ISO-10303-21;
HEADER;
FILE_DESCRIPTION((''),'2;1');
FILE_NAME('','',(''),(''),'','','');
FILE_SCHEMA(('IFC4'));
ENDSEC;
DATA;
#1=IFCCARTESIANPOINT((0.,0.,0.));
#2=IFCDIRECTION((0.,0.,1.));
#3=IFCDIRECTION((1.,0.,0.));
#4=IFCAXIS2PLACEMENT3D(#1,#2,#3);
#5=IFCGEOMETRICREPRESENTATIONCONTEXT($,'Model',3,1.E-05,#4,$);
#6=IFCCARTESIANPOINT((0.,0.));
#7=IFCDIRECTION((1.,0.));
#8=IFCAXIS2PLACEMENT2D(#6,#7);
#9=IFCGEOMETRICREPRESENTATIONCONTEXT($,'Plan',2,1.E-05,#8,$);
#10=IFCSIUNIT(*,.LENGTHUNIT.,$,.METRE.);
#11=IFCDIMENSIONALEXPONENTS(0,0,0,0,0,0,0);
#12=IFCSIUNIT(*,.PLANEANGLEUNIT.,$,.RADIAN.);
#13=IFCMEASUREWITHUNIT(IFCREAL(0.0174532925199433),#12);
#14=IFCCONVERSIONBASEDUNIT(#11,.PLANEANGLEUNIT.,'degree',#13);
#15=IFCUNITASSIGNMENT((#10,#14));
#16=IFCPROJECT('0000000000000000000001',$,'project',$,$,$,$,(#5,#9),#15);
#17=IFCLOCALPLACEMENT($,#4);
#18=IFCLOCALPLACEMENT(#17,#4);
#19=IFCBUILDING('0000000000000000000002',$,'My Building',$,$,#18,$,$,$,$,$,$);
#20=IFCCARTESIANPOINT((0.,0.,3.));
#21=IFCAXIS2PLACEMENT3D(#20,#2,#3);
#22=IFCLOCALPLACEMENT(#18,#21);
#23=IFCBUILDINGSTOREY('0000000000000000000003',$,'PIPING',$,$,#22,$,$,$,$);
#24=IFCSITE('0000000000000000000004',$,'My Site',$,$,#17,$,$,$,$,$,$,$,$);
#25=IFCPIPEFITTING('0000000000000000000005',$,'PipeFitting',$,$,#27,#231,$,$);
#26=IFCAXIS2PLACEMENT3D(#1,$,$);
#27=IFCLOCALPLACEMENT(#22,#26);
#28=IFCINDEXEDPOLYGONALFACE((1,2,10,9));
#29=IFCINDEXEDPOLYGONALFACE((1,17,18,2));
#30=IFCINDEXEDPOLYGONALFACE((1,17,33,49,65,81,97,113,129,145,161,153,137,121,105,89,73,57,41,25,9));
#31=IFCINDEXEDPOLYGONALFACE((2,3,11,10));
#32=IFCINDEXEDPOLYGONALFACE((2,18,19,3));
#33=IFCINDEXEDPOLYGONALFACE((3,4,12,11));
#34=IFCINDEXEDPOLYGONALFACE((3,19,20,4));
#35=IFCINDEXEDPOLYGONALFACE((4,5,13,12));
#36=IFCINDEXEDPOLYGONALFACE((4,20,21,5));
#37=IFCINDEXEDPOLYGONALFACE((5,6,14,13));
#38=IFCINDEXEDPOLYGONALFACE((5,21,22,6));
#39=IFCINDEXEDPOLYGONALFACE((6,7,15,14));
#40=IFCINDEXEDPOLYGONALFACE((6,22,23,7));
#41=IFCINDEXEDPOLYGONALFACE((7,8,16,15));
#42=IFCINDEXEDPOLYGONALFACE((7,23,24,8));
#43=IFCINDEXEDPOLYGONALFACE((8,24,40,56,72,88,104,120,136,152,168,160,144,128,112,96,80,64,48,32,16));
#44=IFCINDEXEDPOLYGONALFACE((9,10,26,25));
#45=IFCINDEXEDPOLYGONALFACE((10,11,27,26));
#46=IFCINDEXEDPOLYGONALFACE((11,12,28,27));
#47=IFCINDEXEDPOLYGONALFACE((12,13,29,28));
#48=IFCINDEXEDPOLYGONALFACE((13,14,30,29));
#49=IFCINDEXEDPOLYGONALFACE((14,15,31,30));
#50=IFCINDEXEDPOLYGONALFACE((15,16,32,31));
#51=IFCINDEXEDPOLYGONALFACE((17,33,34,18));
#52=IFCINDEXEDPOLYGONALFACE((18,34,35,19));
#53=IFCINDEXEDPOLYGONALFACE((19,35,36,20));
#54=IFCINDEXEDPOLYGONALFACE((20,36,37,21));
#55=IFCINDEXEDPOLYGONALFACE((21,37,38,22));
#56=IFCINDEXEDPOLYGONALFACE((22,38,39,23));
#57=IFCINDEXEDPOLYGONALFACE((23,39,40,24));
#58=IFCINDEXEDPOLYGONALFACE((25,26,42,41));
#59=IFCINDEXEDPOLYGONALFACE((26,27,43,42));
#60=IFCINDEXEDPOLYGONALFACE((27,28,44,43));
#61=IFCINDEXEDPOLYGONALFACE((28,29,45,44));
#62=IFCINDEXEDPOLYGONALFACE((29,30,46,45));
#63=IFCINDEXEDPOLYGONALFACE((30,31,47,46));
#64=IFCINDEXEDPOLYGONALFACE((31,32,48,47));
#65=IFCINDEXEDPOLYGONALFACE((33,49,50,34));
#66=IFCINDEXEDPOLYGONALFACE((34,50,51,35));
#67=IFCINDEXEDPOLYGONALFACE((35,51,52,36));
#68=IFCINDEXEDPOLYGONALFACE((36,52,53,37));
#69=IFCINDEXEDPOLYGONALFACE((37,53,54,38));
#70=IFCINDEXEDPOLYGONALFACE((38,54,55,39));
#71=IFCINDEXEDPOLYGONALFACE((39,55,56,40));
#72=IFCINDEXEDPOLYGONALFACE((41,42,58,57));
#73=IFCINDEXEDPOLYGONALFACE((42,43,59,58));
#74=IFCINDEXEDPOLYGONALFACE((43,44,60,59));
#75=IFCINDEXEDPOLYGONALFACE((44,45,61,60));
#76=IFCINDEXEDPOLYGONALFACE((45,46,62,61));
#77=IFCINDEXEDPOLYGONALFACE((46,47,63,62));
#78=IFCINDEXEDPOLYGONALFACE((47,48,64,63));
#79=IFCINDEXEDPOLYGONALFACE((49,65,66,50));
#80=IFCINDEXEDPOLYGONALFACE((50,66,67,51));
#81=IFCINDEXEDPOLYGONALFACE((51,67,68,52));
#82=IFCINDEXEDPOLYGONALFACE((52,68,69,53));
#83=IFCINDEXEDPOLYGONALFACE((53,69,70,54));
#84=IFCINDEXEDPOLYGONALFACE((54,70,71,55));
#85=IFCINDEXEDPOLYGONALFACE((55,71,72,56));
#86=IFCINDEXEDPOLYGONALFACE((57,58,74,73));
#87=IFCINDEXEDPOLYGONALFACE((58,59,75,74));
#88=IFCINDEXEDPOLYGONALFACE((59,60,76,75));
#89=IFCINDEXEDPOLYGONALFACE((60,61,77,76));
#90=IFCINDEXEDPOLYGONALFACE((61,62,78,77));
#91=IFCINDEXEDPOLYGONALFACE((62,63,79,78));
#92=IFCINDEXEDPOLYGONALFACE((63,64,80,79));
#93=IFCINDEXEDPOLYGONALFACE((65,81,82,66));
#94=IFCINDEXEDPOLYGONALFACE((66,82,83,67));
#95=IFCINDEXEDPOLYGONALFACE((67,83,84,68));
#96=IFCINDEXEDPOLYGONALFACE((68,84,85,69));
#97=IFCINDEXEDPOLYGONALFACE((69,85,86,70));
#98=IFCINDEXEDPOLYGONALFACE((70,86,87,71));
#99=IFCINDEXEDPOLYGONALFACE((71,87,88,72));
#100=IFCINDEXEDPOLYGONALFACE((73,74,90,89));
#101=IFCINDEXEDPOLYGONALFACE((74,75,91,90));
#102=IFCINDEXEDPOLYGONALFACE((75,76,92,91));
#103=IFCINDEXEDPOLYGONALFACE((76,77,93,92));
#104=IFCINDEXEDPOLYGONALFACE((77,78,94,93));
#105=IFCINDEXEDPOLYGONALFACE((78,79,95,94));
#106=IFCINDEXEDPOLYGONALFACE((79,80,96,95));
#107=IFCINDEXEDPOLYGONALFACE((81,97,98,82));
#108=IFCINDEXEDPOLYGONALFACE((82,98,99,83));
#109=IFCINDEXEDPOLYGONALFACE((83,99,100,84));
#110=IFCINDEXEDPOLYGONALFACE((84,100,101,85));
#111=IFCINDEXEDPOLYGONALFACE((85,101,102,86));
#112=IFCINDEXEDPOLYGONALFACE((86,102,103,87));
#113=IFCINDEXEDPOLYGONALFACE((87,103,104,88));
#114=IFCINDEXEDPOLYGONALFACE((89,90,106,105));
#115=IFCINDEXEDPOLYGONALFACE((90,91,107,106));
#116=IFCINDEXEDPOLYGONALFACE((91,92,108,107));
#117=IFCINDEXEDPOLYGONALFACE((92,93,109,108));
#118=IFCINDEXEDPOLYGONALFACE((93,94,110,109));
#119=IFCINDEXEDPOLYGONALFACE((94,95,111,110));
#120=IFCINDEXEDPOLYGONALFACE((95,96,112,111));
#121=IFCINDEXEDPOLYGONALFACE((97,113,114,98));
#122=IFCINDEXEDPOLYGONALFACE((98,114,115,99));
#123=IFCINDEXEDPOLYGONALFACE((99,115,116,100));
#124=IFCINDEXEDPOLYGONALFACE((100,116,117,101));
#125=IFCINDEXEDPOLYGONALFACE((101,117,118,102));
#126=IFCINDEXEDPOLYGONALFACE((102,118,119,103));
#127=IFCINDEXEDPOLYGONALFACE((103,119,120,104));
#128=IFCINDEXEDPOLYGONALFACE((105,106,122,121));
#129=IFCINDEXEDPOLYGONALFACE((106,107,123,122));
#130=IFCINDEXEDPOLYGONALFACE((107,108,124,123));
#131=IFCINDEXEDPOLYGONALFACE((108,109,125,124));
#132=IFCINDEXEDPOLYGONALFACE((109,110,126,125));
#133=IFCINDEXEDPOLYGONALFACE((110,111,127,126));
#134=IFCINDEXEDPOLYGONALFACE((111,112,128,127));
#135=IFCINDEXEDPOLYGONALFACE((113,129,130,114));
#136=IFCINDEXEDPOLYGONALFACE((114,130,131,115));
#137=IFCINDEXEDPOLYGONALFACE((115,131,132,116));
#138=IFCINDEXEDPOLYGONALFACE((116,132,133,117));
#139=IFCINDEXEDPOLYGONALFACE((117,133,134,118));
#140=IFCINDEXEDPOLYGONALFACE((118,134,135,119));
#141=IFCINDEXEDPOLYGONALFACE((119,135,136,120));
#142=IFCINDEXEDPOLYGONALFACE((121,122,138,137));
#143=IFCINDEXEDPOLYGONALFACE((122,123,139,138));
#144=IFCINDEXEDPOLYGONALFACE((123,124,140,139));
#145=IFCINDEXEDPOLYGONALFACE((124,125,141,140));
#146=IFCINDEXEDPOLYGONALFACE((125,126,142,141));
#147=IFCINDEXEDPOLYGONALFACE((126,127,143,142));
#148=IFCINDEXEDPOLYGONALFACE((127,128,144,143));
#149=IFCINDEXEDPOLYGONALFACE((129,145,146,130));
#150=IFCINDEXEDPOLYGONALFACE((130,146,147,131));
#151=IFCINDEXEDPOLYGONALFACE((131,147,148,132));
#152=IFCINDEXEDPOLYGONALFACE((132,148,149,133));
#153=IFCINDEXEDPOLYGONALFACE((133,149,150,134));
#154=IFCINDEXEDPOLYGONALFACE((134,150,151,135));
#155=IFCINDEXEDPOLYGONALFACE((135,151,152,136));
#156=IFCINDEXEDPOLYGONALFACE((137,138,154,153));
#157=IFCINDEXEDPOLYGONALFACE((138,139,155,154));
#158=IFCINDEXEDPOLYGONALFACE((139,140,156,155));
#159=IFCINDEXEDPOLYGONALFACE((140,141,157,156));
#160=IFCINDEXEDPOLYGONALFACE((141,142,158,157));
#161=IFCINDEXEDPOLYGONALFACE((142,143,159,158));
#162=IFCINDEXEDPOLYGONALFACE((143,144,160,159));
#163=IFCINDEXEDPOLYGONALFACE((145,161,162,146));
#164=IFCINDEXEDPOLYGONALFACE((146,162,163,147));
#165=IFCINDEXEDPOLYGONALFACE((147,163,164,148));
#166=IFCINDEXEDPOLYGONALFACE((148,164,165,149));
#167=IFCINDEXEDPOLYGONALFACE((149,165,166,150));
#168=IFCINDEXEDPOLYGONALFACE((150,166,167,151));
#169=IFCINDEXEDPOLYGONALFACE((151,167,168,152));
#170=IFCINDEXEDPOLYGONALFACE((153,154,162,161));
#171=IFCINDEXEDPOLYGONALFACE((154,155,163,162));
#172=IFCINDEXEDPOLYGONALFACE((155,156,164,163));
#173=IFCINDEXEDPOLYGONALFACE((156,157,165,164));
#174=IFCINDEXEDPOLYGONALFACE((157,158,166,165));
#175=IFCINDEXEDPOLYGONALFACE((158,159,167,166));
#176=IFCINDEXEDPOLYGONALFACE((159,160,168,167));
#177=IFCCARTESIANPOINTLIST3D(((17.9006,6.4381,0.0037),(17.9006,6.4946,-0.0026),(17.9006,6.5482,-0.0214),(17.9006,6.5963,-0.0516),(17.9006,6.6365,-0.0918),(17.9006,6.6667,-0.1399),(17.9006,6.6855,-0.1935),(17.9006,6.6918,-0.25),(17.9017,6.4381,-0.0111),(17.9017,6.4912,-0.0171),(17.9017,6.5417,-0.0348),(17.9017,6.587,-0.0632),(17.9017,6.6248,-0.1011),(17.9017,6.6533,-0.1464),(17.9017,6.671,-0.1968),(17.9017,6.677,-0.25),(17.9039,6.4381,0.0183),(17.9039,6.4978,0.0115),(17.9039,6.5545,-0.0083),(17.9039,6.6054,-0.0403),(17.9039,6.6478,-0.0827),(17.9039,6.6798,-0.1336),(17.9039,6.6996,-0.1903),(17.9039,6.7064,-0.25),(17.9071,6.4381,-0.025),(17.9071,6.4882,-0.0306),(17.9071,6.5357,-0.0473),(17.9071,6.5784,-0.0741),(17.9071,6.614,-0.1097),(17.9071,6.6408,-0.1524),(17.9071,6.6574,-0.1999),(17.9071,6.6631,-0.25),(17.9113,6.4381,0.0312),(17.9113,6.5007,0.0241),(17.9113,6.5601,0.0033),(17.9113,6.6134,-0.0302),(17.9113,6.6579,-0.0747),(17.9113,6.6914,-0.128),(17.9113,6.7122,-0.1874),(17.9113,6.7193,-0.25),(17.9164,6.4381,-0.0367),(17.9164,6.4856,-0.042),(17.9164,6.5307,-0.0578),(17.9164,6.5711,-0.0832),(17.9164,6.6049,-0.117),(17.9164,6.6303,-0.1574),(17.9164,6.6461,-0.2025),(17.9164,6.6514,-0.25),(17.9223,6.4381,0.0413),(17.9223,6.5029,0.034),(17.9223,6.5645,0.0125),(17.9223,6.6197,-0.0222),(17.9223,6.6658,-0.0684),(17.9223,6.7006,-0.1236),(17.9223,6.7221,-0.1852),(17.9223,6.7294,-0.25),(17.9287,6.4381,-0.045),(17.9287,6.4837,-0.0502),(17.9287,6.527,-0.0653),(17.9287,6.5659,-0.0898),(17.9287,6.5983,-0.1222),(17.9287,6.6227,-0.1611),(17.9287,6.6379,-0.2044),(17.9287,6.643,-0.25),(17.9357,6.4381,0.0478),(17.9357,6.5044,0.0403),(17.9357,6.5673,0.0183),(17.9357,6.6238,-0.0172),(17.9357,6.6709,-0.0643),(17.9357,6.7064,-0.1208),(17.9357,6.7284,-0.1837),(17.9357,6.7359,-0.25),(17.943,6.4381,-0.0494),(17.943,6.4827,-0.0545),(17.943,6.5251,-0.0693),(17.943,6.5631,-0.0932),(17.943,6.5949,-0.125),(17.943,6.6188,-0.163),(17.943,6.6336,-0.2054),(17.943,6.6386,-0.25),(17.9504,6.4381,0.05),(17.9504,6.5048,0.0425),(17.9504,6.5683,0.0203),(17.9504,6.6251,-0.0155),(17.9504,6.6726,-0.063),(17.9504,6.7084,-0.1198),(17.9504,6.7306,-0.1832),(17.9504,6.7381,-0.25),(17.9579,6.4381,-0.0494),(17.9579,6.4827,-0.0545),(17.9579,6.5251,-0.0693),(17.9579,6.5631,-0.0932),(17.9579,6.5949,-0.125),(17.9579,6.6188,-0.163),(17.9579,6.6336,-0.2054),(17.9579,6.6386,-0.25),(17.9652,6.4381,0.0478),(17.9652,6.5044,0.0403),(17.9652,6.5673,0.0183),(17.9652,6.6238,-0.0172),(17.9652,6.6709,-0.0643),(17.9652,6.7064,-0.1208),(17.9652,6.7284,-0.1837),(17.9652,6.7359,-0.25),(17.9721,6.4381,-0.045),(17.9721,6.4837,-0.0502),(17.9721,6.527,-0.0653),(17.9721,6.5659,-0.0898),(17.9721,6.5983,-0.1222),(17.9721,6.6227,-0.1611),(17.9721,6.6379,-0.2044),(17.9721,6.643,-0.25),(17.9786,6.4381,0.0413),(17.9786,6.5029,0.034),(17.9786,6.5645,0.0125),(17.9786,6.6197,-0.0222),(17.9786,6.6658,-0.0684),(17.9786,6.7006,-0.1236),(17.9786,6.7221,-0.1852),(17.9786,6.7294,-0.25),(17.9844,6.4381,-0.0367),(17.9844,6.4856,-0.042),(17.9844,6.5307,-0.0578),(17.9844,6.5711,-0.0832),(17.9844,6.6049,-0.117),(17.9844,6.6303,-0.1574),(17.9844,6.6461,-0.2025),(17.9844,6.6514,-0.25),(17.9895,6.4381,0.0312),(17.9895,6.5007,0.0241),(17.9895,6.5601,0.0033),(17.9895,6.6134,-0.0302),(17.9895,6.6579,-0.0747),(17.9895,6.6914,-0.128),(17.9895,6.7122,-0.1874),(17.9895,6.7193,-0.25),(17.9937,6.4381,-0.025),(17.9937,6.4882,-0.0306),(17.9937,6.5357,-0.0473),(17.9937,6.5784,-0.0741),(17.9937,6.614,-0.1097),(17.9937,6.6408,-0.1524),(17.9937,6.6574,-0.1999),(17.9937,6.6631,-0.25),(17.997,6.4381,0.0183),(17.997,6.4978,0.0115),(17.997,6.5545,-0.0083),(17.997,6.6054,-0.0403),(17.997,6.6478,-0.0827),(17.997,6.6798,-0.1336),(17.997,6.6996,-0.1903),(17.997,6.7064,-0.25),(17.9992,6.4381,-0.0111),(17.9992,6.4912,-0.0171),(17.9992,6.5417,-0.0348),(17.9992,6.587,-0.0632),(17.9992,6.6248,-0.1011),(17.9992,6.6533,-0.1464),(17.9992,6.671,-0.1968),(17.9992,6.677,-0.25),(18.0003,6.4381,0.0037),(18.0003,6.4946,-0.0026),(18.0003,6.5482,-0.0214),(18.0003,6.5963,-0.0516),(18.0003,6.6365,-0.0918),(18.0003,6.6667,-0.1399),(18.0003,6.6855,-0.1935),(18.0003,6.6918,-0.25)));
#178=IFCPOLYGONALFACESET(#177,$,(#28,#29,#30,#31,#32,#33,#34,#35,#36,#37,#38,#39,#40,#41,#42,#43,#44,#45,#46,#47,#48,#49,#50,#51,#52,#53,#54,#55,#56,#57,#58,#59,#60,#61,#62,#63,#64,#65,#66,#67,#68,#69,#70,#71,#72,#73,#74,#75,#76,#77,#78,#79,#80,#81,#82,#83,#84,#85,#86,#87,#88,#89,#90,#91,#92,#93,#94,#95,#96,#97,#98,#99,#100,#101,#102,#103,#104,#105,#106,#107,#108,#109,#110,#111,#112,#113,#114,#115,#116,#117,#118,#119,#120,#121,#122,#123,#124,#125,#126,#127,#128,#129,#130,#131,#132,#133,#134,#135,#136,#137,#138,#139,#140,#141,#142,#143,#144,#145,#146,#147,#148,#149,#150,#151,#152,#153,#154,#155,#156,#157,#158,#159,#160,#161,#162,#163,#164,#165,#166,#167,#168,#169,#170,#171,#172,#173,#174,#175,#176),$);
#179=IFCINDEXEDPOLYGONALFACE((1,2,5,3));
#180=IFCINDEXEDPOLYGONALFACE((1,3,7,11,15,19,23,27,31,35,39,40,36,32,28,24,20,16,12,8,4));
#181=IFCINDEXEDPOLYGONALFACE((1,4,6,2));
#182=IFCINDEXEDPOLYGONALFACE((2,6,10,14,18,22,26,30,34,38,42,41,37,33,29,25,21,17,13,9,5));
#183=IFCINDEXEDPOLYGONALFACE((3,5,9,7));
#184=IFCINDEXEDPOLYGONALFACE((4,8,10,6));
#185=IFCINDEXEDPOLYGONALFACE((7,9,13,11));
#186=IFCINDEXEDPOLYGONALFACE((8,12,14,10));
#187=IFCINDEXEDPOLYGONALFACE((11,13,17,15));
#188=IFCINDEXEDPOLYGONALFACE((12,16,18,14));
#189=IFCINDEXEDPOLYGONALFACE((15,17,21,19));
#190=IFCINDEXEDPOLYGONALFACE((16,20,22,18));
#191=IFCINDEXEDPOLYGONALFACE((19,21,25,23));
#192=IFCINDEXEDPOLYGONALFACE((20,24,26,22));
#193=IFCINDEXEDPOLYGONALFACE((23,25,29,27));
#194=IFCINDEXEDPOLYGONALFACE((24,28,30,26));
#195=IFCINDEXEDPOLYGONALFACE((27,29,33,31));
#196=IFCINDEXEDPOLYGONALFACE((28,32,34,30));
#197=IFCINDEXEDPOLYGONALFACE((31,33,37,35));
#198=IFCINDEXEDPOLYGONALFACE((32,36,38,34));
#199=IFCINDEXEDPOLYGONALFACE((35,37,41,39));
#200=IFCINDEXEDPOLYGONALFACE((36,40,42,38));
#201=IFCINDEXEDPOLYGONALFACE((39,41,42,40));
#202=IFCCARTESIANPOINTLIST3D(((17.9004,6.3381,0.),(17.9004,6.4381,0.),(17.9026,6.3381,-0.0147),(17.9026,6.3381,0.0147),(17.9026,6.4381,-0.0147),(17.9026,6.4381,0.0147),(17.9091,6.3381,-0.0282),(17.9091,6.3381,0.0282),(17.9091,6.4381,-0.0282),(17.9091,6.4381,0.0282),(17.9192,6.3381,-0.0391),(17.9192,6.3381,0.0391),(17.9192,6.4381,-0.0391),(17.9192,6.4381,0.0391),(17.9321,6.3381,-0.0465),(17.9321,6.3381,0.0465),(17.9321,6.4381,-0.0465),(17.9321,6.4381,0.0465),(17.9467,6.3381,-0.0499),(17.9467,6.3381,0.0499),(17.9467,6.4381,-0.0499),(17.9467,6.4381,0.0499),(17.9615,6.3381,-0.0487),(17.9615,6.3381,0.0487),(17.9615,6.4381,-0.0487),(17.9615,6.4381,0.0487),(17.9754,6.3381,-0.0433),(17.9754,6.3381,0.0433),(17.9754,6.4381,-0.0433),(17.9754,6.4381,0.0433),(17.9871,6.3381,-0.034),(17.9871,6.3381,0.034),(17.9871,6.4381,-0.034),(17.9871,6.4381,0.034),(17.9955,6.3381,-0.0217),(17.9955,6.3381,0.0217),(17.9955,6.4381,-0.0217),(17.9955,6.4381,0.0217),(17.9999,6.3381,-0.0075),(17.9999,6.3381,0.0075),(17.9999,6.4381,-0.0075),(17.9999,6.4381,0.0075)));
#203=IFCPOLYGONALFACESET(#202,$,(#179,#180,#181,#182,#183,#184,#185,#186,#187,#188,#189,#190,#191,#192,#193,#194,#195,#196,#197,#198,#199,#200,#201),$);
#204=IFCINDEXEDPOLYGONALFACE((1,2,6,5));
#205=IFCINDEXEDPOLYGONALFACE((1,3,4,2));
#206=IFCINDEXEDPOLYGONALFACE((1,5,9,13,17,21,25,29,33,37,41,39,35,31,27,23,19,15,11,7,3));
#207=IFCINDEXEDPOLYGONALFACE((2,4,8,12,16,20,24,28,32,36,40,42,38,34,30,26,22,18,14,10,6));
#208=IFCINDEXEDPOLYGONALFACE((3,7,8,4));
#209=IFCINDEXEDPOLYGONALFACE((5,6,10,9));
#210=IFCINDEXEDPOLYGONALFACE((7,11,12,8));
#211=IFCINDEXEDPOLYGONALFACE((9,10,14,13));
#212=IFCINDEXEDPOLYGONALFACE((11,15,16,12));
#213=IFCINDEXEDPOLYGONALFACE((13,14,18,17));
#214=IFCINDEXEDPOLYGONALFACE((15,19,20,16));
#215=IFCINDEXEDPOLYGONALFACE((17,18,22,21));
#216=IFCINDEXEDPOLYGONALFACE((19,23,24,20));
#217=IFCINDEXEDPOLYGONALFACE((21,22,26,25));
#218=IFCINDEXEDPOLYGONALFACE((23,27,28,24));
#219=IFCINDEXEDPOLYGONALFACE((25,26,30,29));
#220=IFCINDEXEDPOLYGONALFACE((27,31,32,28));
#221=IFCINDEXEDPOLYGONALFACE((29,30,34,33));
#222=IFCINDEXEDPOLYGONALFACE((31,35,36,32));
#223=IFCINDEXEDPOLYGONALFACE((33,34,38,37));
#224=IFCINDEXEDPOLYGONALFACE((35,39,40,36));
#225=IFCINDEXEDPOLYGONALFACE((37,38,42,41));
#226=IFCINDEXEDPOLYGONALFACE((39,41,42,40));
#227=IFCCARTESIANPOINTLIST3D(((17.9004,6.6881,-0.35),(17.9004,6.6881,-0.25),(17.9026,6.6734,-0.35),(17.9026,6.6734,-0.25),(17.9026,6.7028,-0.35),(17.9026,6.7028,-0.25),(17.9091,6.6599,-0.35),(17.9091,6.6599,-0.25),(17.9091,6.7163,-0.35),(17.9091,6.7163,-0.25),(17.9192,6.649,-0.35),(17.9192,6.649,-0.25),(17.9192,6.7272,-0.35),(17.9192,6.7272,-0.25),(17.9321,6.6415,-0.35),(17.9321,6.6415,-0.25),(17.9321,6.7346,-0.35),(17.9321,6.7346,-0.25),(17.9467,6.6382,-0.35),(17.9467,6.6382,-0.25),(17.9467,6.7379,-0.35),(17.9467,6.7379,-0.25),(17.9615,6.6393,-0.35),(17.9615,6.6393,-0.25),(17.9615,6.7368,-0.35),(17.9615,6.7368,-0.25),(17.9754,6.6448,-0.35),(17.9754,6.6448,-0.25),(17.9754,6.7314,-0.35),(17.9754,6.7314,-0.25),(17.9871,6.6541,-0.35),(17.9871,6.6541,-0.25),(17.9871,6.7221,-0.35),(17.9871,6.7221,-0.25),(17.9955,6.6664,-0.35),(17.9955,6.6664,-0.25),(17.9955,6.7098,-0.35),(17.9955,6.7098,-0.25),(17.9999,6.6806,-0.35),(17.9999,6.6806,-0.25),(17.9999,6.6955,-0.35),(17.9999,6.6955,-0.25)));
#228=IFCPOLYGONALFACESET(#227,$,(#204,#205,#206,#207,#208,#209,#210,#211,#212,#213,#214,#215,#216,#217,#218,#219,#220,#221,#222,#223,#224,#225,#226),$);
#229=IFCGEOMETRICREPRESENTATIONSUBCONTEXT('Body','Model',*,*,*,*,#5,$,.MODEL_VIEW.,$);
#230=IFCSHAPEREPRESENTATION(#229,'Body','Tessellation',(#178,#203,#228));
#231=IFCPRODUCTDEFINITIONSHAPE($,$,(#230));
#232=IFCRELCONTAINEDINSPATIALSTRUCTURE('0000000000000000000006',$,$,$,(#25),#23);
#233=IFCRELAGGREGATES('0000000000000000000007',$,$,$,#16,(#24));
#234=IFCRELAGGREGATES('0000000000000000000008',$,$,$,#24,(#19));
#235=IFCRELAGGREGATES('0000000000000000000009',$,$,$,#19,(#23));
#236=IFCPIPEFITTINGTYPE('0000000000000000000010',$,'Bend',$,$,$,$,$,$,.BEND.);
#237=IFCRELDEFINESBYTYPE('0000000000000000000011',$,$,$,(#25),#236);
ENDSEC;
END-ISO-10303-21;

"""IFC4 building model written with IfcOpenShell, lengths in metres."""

from ifc_helpers import new_model, entity, si_unit, converted_unit, frame, origin_with_axes, origin_2d_with_axis, place, context, subcontext, project, spatial, circle, extrude, source, transform, mapped, type_object, type_shapes, element, save


model = new_model("IFC4")

# Units and contexts
model_context = context("Model", 3, precision=1e-05, world=origin_with_axes())
plan_context = context("Plan", 2, precision=1e-05, world=origin_2d_with_axis())
body_context = subcontext(model_context, "Body", "Model", "MODEL_VIEW")
ifc_project = project(units=[si_unit("LENGTHUNIT", "METRE"), converted_unit("PLANEANGLEUNIT", "degree", entity("IfcReal", 0.0174532925199433), si_unit("PLANEANGLEUNIT", "RADIAN"), dimensions=[0, 0, 0, 0, 0, 0, 0])], contexts=[model_context, plan_context])

# Site, building, storey
site_placement = place(None, origin_with_axes())
site = spatial("IfcSite", under=ifc_project, at=site_placement, Name="My Site")
building_placement = place(site_placement, origin_with_axes())
building = spatial("IfcBuilding", under=site, at=building_placement, Name="My Building")
storey_placement = place(building_placement, frame((0.0, 0.0, 3.0), z_axis=(0.0, 0.0, 1.0), x_axis=(1.0, 0.0, 0.0)))
storey = spatial("IfcBuildingStorey", under=building, at=storey_placement, Name="PIPING")

# Pipe fitting
pipe_fitting_type = type_object("IfcPipeFittingType", Name="Bend", PredefinedType="BEND")
shared_shape = source(origin_with_axes(), body_context, "Body", "SolidModel", [
    entity("IfcSweptDiskSolid", entity("IfcIndexedPolyCurve", entity("IfcCartesianPointList3D", [[0.0, 0.0, 0.1], [0.0, -0.0732, 0.2768], [0.0, -0.25, 0.35]]), [entity("IfcArcIndex", [1, 2, 3])]), 0.05),
    extrude(circle(Radius=0.05), origin_with_axes(), (0.0, 0.0, 1.0), 0.1),
    extrude(circle(Radius=0.05), frame((0.0, -0.25, 0.35), z_axis=(0.0, -1.0, 0.0), x_axis=(1.0, 0.0, 0.0)), (0.0, 0.0, 1.0), 0.1),
])
type_shapes(pipe_fitting_type, [shared_shape])
for number, where, z_axis, x_axis, name in (
    (1, (17.9504, 6.3381, 0.0), (0.0, 1.0, 0.0), (-1.0, 0.0, 0.0), "PipeFitting"),
):
    element("IfcPipeFitting", number, at=place(storey_placement, frame(where, z_axis=z_axis, x_axis=x_axis)), inside=storey, type_object=pipe_fitting_type, Name=name, context=body_context, shape_type="MappedRepresentation", body=[
        mapped(shared_shape, transform((0.0, 0.0, 0.0), x_axis=(1.0, 0.0, 0.0), y_axis=(0.0, 1.0, 0.0), z_axis=(0.0, 0.0, 1.0), scale=1.0)),
    ])

save(model, "model.ifc")
